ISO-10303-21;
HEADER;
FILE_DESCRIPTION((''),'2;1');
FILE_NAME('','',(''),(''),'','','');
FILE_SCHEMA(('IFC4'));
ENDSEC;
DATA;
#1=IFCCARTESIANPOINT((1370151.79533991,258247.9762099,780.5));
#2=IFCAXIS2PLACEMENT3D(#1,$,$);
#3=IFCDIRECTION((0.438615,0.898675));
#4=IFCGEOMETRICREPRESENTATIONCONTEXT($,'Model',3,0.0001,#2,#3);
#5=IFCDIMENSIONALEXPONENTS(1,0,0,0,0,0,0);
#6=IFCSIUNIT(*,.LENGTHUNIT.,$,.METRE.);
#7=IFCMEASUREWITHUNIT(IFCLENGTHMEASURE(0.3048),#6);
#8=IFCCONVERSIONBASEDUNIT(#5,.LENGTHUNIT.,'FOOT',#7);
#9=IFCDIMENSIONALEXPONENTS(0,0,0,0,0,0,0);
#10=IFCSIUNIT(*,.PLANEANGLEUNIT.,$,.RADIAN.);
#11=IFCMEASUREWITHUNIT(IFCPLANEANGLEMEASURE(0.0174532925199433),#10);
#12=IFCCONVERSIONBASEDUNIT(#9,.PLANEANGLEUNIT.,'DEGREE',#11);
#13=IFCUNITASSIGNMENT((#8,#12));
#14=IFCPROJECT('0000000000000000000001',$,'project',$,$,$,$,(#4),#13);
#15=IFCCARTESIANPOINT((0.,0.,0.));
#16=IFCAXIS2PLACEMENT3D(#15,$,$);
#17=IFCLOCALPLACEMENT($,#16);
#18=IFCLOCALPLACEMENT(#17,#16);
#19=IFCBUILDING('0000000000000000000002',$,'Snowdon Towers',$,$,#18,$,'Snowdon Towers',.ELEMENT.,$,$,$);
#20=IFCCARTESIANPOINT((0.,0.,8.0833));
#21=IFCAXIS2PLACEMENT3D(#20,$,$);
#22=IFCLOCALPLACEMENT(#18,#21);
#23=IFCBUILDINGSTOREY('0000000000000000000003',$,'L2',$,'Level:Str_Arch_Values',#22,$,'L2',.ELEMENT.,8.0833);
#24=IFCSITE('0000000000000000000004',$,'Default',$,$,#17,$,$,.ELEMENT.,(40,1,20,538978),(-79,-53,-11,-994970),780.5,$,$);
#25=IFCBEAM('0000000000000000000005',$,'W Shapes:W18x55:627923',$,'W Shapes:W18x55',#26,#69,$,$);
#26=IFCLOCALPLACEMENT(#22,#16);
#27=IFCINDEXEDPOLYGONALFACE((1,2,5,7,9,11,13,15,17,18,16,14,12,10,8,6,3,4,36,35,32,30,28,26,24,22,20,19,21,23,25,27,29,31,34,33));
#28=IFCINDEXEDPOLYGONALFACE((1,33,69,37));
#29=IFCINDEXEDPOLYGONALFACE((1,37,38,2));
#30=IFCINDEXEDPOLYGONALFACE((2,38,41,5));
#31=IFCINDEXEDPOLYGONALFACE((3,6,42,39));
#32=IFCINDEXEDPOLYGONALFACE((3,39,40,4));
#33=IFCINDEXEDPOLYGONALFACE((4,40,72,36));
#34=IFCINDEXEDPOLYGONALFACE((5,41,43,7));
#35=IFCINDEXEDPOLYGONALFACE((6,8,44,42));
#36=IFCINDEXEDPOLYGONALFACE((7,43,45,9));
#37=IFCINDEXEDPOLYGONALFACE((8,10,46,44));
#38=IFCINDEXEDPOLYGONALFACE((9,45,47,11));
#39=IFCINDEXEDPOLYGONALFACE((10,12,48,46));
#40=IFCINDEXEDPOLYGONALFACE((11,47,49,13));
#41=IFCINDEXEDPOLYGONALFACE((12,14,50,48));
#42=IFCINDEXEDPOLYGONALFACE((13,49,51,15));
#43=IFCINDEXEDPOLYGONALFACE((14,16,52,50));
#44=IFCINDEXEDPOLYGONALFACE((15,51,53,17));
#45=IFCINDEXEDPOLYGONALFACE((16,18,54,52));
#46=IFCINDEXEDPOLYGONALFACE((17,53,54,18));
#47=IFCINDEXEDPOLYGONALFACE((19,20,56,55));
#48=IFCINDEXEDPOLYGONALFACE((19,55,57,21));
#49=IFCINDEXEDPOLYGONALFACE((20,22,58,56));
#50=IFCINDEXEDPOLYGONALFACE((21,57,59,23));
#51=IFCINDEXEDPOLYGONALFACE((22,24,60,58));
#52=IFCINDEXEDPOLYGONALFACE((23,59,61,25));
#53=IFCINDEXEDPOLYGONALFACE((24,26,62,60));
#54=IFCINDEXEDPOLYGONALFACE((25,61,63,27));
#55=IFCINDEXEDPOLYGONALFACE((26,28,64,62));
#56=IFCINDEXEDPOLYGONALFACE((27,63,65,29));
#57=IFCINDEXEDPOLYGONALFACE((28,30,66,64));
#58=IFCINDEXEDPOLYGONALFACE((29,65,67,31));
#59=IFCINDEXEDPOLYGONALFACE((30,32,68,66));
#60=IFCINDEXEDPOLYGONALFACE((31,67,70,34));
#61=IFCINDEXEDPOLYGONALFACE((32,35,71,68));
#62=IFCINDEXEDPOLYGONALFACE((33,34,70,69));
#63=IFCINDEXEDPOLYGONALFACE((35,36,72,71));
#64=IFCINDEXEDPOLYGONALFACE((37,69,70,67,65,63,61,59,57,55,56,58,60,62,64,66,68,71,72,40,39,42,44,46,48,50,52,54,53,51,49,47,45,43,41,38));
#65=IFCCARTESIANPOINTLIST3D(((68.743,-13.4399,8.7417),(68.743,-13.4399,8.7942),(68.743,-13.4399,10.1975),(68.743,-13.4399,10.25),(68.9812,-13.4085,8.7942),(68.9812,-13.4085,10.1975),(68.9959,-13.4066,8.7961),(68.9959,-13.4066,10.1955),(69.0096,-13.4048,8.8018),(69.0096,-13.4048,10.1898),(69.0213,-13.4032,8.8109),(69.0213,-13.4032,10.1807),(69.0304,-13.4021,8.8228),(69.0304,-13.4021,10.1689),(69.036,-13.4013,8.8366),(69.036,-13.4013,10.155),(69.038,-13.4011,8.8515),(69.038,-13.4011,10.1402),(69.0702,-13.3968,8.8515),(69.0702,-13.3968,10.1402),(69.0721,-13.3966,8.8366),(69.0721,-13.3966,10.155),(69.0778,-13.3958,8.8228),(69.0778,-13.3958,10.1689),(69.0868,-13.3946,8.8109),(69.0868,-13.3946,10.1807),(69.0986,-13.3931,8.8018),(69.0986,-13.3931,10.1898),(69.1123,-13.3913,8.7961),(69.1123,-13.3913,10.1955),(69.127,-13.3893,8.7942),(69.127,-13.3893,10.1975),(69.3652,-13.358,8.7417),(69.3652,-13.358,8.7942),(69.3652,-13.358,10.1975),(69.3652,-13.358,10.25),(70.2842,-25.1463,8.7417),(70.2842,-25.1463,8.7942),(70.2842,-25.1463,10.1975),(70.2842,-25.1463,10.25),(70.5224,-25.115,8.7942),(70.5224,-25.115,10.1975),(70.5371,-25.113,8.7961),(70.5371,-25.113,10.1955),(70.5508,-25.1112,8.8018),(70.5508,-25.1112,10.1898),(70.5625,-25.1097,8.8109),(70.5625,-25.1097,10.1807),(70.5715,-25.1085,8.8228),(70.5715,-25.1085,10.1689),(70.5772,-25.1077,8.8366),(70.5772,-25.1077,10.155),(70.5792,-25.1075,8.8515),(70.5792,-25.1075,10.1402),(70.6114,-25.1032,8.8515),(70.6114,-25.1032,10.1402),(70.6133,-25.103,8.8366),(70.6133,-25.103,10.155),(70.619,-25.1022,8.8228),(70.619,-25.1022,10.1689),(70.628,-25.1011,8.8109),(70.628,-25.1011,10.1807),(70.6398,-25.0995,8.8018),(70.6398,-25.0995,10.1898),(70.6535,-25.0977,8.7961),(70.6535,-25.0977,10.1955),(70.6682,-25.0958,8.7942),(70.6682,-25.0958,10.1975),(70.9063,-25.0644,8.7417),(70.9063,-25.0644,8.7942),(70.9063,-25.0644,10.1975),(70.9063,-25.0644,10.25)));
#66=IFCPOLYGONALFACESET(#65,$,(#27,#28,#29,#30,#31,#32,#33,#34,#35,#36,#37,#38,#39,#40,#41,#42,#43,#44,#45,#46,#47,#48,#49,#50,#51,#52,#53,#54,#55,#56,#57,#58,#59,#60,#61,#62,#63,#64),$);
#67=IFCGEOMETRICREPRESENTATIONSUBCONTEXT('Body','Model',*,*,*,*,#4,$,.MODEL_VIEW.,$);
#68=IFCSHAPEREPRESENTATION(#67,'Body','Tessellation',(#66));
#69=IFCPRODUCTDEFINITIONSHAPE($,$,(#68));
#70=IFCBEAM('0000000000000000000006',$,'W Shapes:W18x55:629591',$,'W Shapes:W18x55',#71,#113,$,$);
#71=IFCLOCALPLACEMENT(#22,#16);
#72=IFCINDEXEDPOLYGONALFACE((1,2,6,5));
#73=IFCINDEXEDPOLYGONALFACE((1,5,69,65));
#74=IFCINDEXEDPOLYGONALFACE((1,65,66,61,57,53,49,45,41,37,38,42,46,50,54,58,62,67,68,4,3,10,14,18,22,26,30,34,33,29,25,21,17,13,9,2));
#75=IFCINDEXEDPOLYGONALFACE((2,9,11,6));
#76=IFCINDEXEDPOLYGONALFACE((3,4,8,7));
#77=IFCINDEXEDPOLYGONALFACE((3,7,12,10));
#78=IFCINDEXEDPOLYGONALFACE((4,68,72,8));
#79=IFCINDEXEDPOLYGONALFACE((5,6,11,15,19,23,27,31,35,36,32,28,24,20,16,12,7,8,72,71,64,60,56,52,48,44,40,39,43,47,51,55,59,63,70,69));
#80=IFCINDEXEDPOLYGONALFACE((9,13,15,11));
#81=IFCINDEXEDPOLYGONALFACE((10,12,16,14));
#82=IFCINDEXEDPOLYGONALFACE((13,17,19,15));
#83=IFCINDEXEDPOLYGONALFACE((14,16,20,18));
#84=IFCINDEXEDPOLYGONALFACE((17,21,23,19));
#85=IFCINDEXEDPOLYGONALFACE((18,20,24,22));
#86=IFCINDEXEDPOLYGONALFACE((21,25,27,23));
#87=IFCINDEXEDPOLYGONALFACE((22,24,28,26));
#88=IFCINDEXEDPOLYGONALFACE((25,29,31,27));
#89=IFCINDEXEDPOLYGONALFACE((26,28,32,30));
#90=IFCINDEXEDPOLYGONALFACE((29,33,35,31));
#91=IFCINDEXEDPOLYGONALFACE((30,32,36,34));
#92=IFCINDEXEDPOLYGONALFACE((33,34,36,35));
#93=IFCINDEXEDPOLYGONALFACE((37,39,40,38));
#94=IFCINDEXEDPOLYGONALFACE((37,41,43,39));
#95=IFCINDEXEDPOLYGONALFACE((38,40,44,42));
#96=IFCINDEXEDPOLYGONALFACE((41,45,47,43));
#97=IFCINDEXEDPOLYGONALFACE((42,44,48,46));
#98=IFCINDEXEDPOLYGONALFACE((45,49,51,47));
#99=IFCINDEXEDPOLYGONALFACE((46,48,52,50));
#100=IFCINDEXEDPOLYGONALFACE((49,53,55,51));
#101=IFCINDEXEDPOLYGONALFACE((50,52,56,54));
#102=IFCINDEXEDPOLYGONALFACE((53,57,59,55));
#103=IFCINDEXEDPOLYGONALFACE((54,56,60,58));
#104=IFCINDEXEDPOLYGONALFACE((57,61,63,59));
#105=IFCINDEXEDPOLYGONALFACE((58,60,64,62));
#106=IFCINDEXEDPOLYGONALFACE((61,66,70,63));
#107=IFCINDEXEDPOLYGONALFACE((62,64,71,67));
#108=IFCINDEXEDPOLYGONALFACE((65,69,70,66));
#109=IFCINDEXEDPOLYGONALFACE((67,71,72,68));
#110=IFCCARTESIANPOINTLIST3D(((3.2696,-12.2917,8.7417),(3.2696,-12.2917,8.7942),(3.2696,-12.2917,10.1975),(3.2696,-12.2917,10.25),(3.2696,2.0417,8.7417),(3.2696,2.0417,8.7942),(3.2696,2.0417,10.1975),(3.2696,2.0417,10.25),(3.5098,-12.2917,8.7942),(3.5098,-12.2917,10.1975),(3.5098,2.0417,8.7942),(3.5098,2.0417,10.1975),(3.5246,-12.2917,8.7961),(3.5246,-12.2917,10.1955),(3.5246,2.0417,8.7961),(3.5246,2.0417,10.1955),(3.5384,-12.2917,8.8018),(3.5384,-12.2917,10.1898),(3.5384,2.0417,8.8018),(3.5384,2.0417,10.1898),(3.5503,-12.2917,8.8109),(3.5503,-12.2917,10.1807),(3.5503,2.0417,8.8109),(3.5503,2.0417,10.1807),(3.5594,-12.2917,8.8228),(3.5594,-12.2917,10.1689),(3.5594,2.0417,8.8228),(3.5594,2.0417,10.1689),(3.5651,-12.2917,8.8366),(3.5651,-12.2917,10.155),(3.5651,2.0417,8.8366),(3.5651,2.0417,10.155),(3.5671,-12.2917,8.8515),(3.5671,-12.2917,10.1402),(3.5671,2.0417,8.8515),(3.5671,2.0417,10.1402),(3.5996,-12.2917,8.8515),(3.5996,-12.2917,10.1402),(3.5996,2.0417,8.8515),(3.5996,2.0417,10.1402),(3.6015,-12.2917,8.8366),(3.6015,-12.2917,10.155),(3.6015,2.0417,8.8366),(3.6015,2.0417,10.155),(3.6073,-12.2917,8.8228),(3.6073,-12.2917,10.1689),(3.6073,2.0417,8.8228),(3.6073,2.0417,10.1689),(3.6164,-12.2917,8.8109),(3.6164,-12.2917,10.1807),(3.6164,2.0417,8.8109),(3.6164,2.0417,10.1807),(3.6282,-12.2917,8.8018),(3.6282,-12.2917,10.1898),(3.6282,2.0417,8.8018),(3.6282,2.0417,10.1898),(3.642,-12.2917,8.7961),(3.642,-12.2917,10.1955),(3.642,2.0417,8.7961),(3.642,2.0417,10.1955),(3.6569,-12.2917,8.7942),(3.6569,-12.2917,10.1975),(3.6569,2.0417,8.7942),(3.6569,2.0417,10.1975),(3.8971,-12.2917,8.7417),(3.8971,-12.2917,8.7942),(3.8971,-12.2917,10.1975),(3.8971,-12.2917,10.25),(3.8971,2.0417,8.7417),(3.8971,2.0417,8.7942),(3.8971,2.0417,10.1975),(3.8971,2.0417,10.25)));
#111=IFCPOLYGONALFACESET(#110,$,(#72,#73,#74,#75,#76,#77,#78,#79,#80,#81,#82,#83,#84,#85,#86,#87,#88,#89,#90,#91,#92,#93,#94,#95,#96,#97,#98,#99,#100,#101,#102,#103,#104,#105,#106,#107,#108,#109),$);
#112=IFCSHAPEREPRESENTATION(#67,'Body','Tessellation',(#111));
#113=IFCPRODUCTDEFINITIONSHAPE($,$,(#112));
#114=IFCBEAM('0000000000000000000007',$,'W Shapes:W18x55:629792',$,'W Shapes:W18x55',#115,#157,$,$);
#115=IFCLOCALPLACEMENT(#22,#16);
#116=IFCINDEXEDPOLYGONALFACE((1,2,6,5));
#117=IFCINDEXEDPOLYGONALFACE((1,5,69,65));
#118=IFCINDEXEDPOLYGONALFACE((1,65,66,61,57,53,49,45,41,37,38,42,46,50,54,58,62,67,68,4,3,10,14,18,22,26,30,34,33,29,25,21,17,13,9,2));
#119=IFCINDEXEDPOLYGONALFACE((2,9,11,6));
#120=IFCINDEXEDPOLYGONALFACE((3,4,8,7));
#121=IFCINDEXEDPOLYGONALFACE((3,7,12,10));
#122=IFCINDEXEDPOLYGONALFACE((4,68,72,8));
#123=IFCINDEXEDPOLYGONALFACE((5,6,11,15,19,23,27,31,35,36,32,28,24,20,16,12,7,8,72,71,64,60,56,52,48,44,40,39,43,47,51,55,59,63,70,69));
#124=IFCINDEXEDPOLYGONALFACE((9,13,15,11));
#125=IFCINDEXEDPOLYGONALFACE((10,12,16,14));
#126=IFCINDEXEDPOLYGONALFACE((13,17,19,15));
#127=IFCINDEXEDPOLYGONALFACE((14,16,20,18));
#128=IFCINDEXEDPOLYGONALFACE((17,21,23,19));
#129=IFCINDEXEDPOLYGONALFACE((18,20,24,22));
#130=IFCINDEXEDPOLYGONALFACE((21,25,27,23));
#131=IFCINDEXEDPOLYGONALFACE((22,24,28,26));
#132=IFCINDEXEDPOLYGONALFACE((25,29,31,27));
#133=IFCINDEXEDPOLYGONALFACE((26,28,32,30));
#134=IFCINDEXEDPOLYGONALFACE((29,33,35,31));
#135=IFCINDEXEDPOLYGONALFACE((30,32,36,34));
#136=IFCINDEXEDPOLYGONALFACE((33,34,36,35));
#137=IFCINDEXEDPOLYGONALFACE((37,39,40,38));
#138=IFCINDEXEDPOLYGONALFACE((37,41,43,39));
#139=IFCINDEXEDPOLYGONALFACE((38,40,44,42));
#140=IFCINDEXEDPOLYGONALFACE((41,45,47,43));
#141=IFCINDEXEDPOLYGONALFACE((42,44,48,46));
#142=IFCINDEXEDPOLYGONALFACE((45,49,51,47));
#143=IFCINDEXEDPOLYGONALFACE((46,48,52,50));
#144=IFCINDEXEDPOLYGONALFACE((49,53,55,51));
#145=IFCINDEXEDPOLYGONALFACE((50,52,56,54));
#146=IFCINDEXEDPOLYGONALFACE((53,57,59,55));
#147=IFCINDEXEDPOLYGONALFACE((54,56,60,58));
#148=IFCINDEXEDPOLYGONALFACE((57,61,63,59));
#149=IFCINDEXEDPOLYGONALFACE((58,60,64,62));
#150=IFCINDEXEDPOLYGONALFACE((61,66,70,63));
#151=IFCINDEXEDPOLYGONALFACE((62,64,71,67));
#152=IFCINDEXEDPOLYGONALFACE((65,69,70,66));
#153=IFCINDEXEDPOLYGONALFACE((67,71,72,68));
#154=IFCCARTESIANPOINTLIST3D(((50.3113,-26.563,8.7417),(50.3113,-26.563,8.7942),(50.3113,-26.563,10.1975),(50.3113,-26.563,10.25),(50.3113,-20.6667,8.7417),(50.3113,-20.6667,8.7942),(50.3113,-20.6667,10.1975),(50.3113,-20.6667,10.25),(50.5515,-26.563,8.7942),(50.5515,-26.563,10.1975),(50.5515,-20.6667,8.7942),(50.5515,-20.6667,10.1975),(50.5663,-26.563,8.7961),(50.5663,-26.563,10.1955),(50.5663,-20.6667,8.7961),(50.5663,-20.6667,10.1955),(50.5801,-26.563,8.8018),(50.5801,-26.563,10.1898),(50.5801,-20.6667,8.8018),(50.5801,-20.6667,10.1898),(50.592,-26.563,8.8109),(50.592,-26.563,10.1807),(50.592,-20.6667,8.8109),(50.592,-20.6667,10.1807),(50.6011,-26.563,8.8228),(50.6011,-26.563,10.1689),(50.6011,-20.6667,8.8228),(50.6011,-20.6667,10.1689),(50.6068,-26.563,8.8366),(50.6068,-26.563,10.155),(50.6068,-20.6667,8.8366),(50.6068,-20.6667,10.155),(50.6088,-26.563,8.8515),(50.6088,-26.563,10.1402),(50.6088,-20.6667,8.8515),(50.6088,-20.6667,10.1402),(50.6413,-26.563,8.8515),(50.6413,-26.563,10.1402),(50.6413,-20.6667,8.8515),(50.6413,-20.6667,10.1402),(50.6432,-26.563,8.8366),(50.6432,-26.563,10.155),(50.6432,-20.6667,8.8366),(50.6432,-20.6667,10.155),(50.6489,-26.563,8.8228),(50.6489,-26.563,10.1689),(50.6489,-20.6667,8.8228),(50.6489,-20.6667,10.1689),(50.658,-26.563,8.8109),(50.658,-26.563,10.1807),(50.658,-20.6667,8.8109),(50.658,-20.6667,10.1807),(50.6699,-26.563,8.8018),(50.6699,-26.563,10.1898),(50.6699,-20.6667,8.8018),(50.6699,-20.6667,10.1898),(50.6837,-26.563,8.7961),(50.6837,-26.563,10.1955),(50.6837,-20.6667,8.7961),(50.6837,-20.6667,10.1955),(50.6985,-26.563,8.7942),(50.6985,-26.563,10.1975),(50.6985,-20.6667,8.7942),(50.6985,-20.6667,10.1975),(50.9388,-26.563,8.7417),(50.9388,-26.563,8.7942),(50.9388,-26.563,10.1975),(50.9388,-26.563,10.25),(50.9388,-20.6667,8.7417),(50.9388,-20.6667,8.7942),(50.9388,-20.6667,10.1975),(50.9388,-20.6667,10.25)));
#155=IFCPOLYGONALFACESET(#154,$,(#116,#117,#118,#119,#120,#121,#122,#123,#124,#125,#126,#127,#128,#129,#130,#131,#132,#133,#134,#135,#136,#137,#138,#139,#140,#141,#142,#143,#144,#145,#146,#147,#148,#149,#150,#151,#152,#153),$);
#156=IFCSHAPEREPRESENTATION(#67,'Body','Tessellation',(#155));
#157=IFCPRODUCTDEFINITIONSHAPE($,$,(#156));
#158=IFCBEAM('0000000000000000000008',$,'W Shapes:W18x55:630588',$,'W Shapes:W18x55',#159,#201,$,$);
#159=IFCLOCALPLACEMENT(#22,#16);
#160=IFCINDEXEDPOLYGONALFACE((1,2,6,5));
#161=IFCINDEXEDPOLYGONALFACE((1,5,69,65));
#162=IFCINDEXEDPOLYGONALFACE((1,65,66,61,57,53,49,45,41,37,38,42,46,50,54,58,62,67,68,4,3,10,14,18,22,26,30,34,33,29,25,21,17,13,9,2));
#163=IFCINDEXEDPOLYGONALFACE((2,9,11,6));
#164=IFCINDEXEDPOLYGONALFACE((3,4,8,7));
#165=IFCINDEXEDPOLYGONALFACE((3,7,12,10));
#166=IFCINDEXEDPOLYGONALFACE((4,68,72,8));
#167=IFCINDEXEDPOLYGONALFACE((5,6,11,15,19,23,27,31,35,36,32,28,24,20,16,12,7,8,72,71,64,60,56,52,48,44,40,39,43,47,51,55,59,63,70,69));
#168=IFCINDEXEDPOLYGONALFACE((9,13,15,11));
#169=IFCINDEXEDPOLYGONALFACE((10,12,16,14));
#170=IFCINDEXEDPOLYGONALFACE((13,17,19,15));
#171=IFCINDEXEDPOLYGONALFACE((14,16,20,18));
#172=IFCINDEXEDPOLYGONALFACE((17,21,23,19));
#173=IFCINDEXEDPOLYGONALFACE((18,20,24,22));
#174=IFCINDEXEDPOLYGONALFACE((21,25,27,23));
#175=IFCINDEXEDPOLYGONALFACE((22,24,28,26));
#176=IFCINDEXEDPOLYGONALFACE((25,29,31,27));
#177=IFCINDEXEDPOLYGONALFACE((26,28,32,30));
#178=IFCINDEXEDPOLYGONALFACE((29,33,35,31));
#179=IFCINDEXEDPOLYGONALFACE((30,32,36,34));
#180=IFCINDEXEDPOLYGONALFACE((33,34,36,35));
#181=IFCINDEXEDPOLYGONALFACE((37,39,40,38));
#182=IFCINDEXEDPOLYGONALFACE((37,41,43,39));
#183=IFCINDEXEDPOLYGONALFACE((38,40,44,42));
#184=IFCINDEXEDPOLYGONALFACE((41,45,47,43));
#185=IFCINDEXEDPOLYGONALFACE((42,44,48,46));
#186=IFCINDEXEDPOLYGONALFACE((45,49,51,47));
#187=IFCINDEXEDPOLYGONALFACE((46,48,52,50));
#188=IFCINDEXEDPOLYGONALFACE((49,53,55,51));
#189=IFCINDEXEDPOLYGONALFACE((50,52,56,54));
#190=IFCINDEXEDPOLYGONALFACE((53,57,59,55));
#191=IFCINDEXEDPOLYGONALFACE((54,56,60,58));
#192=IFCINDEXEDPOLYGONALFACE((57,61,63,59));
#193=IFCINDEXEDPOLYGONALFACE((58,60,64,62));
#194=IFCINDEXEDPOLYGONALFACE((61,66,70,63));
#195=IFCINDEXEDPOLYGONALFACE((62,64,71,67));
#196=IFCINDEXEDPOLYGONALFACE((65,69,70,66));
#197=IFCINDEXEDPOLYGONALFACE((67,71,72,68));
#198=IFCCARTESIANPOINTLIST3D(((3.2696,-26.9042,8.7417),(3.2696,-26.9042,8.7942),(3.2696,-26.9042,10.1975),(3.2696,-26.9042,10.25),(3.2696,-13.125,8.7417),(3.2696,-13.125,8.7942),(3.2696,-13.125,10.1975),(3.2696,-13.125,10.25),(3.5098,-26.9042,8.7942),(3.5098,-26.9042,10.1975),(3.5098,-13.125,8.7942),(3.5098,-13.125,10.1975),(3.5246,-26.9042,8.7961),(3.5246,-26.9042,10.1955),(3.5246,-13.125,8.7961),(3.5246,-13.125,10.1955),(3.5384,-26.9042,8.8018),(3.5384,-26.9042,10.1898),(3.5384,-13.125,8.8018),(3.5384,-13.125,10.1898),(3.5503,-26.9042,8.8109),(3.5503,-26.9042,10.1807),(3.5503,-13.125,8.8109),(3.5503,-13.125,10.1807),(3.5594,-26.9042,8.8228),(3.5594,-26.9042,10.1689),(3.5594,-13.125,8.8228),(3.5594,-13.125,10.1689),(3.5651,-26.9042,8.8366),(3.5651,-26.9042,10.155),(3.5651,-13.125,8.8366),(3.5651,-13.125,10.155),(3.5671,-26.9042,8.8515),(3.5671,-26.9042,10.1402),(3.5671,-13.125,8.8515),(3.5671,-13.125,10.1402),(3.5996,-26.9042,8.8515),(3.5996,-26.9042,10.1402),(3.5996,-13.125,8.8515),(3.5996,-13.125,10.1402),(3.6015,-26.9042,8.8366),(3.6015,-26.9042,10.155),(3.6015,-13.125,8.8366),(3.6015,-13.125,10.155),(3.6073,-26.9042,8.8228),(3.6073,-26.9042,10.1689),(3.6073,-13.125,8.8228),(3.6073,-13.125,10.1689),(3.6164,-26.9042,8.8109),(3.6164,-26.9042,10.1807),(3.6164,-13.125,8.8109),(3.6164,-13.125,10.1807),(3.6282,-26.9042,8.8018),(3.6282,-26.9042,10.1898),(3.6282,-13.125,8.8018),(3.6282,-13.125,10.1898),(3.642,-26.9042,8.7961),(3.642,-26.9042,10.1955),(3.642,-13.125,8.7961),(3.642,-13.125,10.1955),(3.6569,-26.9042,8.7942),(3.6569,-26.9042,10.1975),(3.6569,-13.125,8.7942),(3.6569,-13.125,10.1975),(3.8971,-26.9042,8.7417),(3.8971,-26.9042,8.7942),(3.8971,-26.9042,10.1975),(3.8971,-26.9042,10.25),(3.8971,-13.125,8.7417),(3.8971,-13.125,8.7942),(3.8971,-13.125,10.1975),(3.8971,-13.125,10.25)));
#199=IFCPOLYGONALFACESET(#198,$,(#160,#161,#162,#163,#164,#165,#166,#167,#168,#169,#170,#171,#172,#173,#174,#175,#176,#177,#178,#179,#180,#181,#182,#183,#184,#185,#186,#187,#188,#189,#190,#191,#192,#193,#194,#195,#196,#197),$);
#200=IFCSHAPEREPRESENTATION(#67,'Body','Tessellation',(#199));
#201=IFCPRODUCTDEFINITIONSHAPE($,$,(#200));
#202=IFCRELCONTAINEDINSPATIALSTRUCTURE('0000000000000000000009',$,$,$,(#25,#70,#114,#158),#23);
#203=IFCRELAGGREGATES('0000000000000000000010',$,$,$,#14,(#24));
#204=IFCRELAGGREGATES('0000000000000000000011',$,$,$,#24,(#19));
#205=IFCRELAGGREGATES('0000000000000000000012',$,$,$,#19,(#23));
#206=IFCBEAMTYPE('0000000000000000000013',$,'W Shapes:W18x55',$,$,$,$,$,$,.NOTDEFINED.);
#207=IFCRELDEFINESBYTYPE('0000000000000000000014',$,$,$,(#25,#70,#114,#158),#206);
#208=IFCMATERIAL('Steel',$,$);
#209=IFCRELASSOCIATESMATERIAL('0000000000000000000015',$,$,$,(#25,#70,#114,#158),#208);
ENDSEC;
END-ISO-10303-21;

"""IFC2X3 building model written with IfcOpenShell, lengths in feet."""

from ifc_helpers import new_model, entity, si_unit, converted_unit, direction, frame, frame_2d, origin, place, context, subcontext, project, spatial, i_section, extrude, material, type_object, element, save


model = new_model("IFC2X3")

# Units and contexts
model_context = context("Model", 3, precision=0.0001, world=frame((1370151.79533991, 258247.9762099, 780.5)), true_north=direction((0.438615, 0.898675)))
body_context = subcontext(model_context, "Body", "Model", "MODEL_VIEW")
ifc_project = project(units=[converted_unit("LENGTHUNIT", "FOOT", entity("IfcLengthMeasure", 0.3048), si_unit("LENGTHUNIT", "METRE"), dimensions=[1, 0, 0, 0, 0, 0, 0]), converted_unit("PLANEANGLEUNIT", "DEGREE", entity("IfcPlaneAngleMeasure", 0.0174532925199433), si_unit("PLANEANGLEUNIT", "RADIAN"), dimensions=[0, 0, 0, 0, 0, 0, 0])], contexts=[model_context])

# Site, building, storey
site_placement = place(None, origin())
site = spatial("IfcSite", under=ifc_project, at=site_placement, Name="Default", CompositionType="ELEMENT", RefLatitude=(40, 1, 20, 538978), RefLongitude=(-79, -53, -11, -994970), RefElevation=780.5)
building_placement = place(site_placement, origin())
building = spatial("IfcBuilding", under=site, at=building_placement, Name="Snowdon Towers", LongName="Snowdon Towers", CompositionType="ELEMENT")
storey_placement = place(building_placement, frame((0.0, 0.0, 8.0833)))
storey = spatial("IfcBuildingStorey", under=building, at=storey_placement, Name="L2", ObjectType="Level:Str_Arch_Values", LongName="L2", CompositionType="ELEMENT", Elevation=8.0833)

# Beams
ifc_material = material(Name="Steel")
beam_type_1 = type_object("IfcBeamType", Name="W Shapes:W18x55", PredefinedType="NOTDEFINED")
beam_1_placement = place(storey_placement, frame((68.9732, -12.7845, 10.25), z_axis=(0.0, 0.0, 1.0), x_axis=(0.130526, -0.991445, 0.0)))
element("IfcBeam", 1, at=beam_1_placement, inside=storey, type_object=beam_type_1, material=ifc_material, Name="W Shapes:W18x55:627923", ObjectType="W Shapes:W18x55", context=body_context, shape_type="SweptSolid", body=[
    extrude(i_section(OverallWidth=0.6275, OverallDepth=1.5083, WebThickness=0.0325, FlangeThickness=0.0525, FilletRadius=0.0573, at=frame_2d((0.0, 0.0), x_axis=(0.0, 1.0))), frame((0.6198, 0.0, -0.7542), z_axis=(1.0, 0.0, 0.0), x_axis=(0.0, 0.0, -1.0)), (0.0, 0.0, 1.0), 11.8075),
])
beam_2_placement = place(storey_placement, frame((3.5833, 2.5, 10.25), z_axis=(0.0, 0.0, 1.0), x_axis=(0.0, -1.0, 0.0)))
element("IfcBeam", 2, at=beam_2_placement, inside=storey, type_object=beam_type_1, material=ifc_material, Name="W Shapes:W18x55:629591", ObjectType="W Shapes:W18x55", context=body_context, shape_type="SweptSolid", body=[
    extrude(i_section(OverallWidth=0.6275, OverallDepth=1.5083, WebThickness=0.0325, FlangeThickness=0.0525, FilletRadius=0.0573, at=frame_2d((0.0, 0.0), x_axis=(0.0, 1.0))), frame((0.4583, 0.0, -0.7542), z_axis=(1.0, 0.0, 0.0), x_axis=(0.0, 0.0, -1.0)), (0.0, 0.0, 1.0), 14.3333),
])
beam_3_placement = place(storey_placement, frame((50.625, -20.125, 10.25), z_axis=(0.0, 0.0, 1.0), x_axis=(0.0, -1.0, 0.0)))
element("IfcBeam", 3, at=beam_3_placement, inside=storey, type_object=beam_type_1, material=ifc_material, Name="W Shapes:W18x55:629792", ObjectType="W Shapes:W18x55", context=body_context, shape_type="SweptSolid", body=[
    extrude(i_section(OverallWidth=0.6275, OverallDepth=1.5083, WebThickness=0.0325, FlangeThickness=0.0525, FilletRadius=0.0573, at=frame_2d((0.0, 0.0), x_axis=(0.0, 1.0))), frame((0.5417, 0.0, -0.7542), z_axis=(1.0, 0.0, 0.0), x_axis=(0.0, 0.0, -1.0)), (0.0, 0.0, 1.0), 5.8964),
])
beam_4_placement = place(storey_placement, frame((3.5833, -12.7083, 10.25), z_axis=(0.0, 0.0, 1.0), x_axis=(0.0, -1.0, 0.0)))
element("IfcBeam", 4, at=beam_4_placement, inside=storey, type_object=beam_type_1, material=ifc_material, Name="W Shapes:W18x55:630588", ObjectType="W Shapes:W18x55", context=body_context, shape_type="SweptSolid", body=[
    extrude(i_section(OverallWidth=0.6275, OverallDepth=1.5083, WebThickness=0.0325, FlangeThickness=0.0525, FilletRadius=0.0573, at=frame_2d((0.0, 0.0), x_axis=(0.0, 1.0))), frame((0.4167, 0.0, -0.7542), z_axis=(1.0, 0.0, 0.0), x_axis=(0.0, 0.0, -1.0)), (0.0, 0.0, 1.0), 13.7792),
])

save(model, "model.ifc")
